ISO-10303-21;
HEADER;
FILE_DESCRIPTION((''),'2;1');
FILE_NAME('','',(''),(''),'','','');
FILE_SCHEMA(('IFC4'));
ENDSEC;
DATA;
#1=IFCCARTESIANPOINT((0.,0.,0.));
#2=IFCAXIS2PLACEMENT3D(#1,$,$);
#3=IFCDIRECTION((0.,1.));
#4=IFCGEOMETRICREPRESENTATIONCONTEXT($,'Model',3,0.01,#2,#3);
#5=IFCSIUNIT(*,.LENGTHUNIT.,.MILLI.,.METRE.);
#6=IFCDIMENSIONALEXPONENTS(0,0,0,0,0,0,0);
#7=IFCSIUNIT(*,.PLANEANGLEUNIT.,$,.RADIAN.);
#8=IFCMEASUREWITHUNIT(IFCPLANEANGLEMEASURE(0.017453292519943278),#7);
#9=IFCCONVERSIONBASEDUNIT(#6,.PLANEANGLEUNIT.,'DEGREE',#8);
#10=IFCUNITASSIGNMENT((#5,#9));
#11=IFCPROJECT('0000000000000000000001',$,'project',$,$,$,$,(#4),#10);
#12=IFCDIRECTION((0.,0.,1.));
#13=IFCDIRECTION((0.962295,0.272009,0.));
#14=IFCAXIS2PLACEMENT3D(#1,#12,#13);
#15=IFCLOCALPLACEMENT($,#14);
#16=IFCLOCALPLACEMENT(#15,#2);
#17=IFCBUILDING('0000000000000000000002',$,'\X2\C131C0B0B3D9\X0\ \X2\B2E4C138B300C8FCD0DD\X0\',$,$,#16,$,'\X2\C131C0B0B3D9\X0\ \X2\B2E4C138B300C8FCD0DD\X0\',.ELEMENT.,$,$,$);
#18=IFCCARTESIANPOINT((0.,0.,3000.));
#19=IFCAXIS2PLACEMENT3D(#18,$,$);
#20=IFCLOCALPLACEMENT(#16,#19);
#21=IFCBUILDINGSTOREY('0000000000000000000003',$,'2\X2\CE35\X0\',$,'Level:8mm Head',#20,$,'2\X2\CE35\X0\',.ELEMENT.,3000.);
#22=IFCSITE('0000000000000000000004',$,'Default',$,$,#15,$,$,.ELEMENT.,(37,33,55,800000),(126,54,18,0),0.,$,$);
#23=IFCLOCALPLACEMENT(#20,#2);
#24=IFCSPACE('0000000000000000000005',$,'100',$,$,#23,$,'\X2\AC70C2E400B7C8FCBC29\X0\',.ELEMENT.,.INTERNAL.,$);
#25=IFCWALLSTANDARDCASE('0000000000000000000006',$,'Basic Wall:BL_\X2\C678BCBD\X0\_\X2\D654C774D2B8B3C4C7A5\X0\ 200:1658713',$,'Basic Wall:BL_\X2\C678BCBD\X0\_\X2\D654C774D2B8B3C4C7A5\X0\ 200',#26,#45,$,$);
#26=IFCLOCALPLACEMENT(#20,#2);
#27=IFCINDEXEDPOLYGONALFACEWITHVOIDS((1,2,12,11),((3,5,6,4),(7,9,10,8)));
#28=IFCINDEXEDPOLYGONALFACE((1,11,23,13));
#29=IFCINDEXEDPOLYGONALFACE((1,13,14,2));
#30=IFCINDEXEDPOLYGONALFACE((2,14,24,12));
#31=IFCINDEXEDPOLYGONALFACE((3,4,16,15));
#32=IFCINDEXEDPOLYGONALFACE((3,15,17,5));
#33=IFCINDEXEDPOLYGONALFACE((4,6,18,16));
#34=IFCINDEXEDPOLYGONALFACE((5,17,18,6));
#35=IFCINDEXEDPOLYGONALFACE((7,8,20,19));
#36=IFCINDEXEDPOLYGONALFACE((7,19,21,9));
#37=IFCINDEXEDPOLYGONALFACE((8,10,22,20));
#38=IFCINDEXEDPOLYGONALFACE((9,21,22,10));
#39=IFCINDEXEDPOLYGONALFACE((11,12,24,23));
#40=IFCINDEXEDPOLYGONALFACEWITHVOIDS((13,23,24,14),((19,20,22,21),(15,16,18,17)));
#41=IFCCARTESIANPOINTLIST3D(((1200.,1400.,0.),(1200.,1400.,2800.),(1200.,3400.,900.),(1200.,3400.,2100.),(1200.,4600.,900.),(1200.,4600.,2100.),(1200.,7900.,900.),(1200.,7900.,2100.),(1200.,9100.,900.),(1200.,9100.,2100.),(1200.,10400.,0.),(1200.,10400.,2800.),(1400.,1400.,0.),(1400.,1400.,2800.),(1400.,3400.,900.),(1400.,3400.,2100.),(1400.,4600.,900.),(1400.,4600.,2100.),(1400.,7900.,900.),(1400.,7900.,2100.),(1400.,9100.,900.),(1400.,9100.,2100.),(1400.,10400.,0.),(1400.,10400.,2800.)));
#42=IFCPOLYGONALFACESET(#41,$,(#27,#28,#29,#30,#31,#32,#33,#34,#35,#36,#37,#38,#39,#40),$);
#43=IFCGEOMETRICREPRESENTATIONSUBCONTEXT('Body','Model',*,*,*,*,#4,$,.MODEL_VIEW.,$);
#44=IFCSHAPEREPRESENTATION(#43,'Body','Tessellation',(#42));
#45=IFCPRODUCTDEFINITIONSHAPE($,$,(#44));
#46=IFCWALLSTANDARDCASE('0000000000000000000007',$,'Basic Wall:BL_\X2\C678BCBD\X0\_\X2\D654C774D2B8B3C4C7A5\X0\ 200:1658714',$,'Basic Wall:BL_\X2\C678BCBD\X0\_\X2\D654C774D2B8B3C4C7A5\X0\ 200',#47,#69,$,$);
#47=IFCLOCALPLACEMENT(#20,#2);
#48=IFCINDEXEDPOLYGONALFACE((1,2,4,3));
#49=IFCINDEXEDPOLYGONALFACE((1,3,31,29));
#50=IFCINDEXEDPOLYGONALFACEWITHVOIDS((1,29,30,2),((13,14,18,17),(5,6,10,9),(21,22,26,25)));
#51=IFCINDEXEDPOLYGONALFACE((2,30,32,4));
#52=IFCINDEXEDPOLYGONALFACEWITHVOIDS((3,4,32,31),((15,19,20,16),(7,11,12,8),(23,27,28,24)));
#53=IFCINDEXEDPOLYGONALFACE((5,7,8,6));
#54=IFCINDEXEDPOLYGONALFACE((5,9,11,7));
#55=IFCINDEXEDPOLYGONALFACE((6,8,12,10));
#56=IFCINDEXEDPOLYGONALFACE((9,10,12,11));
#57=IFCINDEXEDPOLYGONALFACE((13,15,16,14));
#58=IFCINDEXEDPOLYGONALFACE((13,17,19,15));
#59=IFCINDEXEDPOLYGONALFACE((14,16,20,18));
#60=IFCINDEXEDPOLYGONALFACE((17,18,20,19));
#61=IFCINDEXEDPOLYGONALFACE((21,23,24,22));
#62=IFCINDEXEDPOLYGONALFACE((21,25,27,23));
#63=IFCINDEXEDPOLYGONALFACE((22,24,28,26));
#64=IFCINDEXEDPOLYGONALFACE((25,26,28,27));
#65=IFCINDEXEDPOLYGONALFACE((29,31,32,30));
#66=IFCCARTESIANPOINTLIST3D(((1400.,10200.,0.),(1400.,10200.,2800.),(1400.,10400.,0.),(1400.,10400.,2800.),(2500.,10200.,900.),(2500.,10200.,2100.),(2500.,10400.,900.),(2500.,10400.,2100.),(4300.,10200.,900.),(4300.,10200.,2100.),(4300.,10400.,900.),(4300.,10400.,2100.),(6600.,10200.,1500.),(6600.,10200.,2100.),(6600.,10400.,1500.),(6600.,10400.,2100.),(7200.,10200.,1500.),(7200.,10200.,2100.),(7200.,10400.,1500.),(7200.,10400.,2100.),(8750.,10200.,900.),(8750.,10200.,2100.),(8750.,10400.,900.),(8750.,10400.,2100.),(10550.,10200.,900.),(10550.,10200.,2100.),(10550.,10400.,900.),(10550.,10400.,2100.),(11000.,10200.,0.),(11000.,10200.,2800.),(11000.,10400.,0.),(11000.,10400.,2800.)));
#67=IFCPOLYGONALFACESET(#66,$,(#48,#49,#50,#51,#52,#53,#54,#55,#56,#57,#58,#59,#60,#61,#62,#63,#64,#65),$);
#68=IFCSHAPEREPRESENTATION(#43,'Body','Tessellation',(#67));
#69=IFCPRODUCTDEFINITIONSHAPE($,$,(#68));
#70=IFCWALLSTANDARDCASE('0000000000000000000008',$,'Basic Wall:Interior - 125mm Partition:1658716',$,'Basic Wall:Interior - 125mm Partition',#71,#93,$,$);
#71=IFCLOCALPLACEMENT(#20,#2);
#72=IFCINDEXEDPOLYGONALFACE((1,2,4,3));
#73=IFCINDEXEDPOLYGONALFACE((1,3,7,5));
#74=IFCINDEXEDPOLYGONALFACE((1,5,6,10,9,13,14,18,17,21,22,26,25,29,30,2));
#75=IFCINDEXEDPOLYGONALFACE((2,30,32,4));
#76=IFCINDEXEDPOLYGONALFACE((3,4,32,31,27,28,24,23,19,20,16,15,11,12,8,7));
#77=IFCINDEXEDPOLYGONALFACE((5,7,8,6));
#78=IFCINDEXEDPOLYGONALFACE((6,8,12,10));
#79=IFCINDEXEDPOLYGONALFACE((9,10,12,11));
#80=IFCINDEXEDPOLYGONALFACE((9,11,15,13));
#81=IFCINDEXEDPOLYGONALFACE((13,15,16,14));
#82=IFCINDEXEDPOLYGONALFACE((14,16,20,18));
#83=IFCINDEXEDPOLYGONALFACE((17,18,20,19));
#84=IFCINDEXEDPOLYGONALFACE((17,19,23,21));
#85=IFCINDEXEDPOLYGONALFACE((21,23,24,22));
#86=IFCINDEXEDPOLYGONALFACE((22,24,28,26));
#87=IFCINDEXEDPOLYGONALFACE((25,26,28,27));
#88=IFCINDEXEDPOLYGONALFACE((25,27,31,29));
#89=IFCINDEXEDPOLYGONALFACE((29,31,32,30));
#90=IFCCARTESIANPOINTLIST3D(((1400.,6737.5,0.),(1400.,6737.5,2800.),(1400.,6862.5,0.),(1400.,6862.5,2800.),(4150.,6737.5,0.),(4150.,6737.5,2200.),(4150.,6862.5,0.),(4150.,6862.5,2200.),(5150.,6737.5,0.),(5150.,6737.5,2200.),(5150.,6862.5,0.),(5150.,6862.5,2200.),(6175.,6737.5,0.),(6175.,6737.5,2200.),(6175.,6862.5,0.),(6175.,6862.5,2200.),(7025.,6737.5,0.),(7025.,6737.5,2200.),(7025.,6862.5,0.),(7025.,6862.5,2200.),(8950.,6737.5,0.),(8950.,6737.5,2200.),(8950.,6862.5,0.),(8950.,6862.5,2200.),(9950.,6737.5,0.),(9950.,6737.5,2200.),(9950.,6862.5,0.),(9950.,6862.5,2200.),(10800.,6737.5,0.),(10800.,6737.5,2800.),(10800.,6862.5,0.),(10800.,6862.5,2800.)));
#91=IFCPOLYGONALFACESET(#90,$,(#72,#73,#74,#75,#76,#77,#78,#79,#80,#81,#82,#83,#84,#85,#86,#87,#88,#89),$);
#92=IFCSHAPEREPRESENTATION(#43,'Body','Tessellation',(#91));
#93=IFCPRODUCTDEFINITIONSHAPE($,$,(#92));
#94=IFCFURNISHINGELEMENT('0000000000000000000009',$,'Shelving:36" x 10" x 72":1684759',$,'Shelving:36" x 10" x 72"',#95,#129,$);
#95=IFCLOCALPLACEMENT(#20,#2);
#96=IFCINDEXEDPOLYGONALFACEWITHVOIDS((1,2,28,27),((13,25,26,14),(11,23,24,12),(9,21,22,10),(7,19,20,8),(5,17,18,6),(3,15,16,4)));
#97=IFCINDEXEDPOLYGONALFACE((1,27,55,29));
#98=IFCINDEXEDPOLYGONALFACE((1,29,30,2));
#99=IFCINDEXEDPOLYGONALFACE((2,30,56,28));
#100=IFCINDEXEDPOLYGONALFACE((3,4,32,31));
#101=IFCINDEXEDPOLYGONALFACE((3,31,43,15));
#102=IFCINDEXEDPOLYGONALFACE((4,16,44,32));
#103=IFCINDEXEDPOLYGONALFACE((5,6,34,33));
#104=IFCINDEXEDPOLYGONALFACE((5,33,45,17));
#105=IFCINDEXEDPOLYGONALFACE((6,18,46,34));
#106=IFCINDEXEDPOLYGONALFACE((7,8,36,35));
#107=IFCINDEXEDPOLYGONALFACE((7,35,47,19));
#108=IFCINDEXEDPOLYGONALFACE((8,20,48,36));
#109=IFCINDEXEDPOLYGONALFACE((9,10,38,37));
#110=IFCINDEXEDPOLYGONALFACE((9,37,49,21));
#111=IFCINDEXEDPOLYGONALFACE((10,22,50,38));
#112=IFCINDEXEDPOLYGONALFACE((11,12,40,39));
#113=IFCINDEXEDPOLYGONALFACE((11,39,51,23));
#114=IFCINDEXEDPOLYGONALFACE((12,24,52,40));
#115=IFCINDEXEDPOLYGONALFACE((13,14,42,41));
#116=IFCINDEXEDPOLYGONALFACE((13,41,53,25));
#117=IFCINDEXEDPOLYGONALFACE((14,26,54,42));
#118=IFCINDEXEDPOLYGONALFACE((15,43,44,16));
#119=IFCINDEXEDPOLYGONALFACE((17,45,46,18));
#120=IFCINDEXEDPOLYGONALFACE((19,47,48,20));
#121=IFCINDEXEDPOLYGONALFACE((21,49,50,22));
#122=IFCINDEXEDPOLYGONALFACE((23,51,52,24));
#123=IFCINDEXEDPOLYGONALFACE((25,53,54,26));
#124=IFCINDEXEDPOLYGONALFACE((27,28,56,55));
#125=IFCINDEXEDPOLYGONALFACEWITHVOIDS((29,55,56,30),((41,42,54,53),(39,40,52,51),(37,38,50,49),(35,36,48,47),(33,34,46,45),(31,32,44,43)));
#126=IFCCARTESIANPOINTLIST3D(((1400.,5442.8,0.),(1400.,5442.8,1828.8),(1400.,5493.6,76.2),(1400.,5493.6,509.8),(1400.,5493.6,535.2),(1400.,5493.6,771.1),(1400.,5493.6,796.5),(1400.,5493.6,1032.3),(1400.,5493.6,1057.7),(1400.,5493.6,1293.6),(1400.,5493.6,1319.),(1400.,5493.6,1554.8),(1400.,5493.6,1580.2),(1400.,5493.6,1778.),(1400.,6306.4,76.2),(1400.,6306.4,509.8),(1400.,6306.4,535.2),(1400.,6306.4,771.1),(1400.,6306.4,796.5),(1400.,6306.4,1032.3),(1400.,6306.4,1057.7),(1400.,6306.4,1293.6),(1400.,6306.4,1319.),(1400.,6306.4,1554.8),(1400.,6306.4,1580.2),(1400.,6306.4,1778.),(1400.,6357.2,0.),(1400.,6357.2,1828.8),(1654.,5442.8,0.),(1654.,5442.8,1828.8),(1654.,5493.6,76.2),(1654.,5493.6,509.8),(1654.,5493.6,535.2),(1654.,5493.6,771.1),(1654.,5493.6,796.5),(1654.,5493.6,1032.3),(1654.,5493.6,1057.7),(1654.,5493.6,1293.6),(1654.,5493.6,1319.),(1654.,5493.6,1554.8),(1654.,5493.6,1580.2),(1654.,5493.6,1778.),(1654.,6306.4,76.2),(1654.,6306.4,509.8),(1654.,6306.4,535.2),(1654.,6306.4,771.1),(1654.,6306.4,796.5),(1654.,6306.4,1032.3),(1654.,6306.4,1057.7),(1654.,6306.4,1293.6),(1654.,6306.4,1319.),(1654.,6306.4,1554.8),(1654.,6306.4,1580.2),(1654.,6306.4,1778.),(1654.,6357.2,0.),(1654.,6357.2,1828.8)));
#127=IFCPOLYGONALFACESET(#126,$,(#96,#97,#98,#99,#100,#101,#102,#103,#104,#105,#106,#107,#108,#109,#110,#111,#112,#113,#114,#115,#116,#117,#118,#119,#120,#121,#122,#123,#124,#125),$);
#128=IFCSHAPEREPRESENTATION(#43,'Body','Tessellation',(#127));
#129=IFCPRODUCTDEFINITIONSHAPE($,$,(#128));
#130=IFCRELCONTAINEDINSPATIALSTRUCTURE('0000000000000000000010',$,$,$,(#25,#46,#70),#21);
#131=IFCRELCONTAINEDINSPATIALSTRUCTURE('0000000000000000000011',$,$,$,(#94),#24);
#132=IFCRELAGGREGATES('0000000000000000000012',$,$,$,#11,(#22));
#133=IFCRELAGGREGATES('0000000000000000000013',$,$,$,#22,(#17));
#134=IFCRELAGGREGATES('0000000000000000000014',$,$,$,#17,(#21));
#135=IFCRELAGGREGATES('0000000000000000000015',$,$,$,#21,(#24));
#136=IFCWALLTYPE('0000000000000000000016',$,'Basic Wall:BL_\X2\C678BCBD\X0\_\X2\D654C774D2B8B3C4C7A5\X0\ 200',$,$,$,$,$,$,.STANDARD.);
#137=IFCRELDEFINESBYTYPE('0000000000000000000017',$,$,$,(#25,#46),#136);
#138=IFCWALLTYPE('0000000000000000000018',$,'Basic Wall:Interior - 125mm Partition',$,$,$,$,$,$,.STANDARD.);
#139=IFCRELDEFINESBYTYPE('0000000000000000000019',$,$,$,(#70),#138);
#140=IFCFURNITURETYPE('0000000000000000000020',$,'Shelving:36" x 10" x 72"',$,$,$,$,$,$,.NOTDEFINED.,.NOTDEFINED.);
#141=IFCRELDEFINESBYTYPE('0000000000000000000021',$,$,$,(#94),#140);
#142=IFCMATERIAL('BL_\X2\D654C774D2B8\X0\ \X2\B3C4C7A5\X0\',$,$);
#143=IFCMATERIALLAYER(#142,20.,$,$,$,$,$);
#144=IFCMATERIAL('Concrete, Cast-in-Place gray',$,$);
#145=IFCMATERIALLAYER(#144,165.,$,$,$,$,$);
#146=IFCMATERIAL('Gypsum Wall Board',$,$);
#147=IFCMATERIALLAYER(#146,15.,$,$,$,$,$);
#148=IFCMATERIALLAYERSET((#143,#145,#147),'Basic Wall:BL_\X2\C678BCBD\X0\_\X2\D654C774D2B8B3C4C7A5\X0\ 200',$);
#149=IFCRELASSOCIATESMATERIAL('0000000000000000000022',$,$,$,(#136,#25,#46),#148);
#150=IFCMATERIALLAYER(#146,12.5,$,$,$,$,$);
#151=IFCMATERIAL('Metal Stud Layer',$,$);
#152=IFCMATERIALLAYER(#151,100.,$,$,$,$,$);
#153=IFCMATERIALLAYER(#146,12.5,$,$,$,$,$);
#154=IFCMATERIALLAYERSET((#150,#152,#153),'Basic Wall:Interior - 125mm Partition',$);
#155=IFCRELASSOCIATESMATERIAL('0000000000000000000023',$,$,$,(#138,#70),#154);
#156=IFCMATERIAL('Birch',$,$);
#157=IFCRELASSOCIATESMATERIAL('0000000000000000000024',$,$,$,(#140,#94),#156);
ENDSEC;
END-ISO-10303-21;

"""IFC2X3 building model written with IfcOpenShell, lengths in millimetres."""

from ifc_helpers import new_model, entity, si_unit, converted_unit, direction, frame, frame_2d, origin, place, context, subcontext, project, spatial, polyline, rectangle, outline, extrude, source, transform, mapped, material, layer, layer_set, layer_usage, type_object, type_shapes, element, save


model = new_model("IFC2X3")

# Units and contexts
model_context = context("Model", 3, precision=0.01, world=origin(), true_north=direction((0.0, 1.0)))
body_context = subcontext(model_context, "Body", "Model", "MODEL_VIEW")
ifc_project = project(units=[si_unit("LENGTHUNIT", "METRE", prefix="MILLI"), converted_unit("PLANEANGLEUNIT", "DEGREE", entity("IfcPlaneAngleMeasure", 0.017453292519943278), si_unit("PLANEANGLEUNIT", "RADIAN"), dimensions=[0, 0, 0, 0, 0, 0, 0])], contexts=[model_context])

# Site, building, storey
site_placement = place(None, frame((0.0, 0.0, 0.0), z_axis=(0.0, 0.0, 1.0), x_axis=(0.962295, 0.272009, 0.0)))
site = spatial("IfcSite", under=ifc_project, at=site_placement, Name="Default", CompositionType="ELEMENT", RefLatitude=(37, 33, 55, 800000), RefLongitude=(126, 54, 18, 0), RefElevation=0.0)
building_placement = place(site_placement, origin())
building = spatial("IfcBuilding", under=site, at=building_placement, Name="성산동 다세대주택", LongName="성산동 다세대주택", CompositionType="ELEMENT")
storey_placement = place(building_placement, frame((0.0, 0.0, 3000.0)))
storey = spatial("IfcBuildingStorey", under=building, at=storey_placement, Name="2층", ObjectType="Level:8mm Head", LongName="2층", CompositionType="ELEMENT", Elevation=3000.0)

# Walls, openings
ifc_material_1 = material(Name="BL_화이트 도장")
ifc_layer_1 = layer(ifc_material_1, 20.0)
ifc_material_2 = material(Name="Concrete, Cast-in-Place gray")
ifc_layer_2 = layer(ifc_material_2, 165.0)
ifc_material_3 = material(Name="Gypsum Wall Board")
ifc_layer_3 = layer(ifc_material_3, 15.0)
ifc_layer_set_1 = layer_set([ifc_layer_1, ifc_layer_2, ifc_layer_3], Name="Basic Wall:BL_외벽_화이트도장 200")
ifc_layer_usage_1 = layer_usage(ifc_layer_set_1, "AXIS2", "NEGATIVE", 100.0)
wall_type_1 = type_object("IfcWallType", Name="Basic Wall:BL_외벽_화이트도장 200", PredefinedType="STANDARD", material=ifc_layer_set_1)
wall_1_placement = place(storey_placement, frame((1300.0, 1400.0, 0.0), z_axis=(0.0, 0.0, 1.0), x_axis=(0.0, 1.0, 0.0)))
wall_1 = element("IfcWallStandardCase", 1, at=wall_1_placement, inside=storey, type_object=wall_type_1, material=ifc_layer_usage_1, Name="Basic Wall:BL_외벽_화이트도장 200:1658713", ObjectType="Basic Wall:BL_외벽_화이트도장 200", context=body_context, shape_type="SweptSolid", body=[
    extrude(rectangle(XDim=9000.0, YDim=200.0, at=frame_2d((4500.0, 0.0), x_axis=(-1.0, 0.0))), origin(), (0.0, 0.0, 1.0), 2800.0),
])
opening_1_placement = place(wall_1_placement, frame((2000.0, -100.0, 900.0)))
element("IfcOpeningElement", 2, at=opening_1_placement, cuts=wall_1, ObjectType="Opening", context=body_context, shape_type="SweptSolid", body=[
    extrude(rectangle(XDim=1200.0, YDim=1200.0, at=frame_2d((600.0, 600.0), x_axis=(-1.0, 0.0))), frame((0.0, 0.0, 0.0), z_axis=(0.0, 1.0, 0.0), x_axis=(0.0, 0.0, 1.0)), (0.0, 0.0, 1.0), 200.0),
])
opening_2_placement = place(wall_1_placement, frame((6500.0, -100.0, 900.0)))
element("IfcOpeningElement", 3, at=opening_2_placement, cuts=wall_1, ObjectType="Opening", context=body_context, shape_type="SweptSolid", body=[
    extrude(rectangle(XDim=1200.0, YDim=1200.0, at=frame_2d((600.0, 600.0), x_axis=(-1.0, 0.0))), frame((0.0, 0.0, 0.0), z_axis=(0.0, 1.0, 0.0), x_axis=(0.0, 0.0, 1.0)), (0.0, 0.0, 1.0), 200.0),
])
ifc_layer_usage_2 = layer_usage(ifc_layer_set_1, "AXIS2", "NEGATIVE", 100.0)
wall_2_placement = place(storey_placement, frame((1400.0, 10300.0, 0.0)))
wall_2 = element("IfcWallStandardCase", 4, at=wall_2_placement, inside=storey, type_object=wall_type_1, material=ifc_layer_usage_2, Name="Basic Wall:BL_외벽_화이트도장 200:1658714", ObjectType="Basic Wall:BL_외벽_화이트도장 200", context=body_context, shape_type="SweptSolid", body=[
    extrude(rectangle(XDim=9600.0, YDim=200.0, at=frame_2d((4800.0, 0.0), x_axis=(-1.0, 0.0))), origin(), (0.0, 0.0, 1.0), 2800.0),
])
opening_3_placement = place(wall_2_placement, frame((1100.0, -100.0, 900.0)))
element("IfcOpeningElement", 5, at=opening_3_placement, cuts=wall_2, ObjectType="Opening", context=body_context, shape_type="SweptSolid", body=[
    extrude(rectangle(XDim=1200.0, YDim=1800.0, at=frame_2d((600.0, 900.0), x_axis=(-1.0, 0.0))), frame((0.0, 0.0, 0.0), z_axis=(0.0, 1.0, 0.0), x_axis=(0.0, 0.0, 1.0)), (0.0, 0.0, 1.0), 200.0),
])
opening_4_placement = place(wall_2_placement, frame((5200.0, -100.0, 1500.0)))
element("IfcOpeningElement", 6, at=opening_4_placement, cuts=wall_2, ObjectType="Opening", context=body_context, shape_type="SweptSolid", body=[
    extrude(rectangle(XDim=600.0, YDim=600.0, at=frame_2d((300.0, 300.0), x_axis=(-1.0, 0.0))), frame((0.0, 0.0, 0.0), z_axis=(0.0, 1.0, 0.0), x_axis=(0.0, 0.0, 1.0)), (0.0, 0.0, 1.0), 200.0),
])
opening_5_placement = place(wall_2_placement, frame((7350.0, -100.0, 900.0)))
element("IfcOpeningElement", 7, at=opening_5_placement, cuts=wall_2, ObjectType="Opening", context=body_context, shape_type="SweptSolid", body=[
    extrude(rectangle(XDim=1200.0, YDim=1800.0, at=frame_2d((600.0, 900.0), x_axis=(-1.0, 0.0))), frame((0.0, 0.0, 0.0), z_axis=(0.0, 1.0, 0.0), x_axis=(0.0, 0.0, 1.0)), (0.0, 0.0, 1.0), 200.0),
])
ifc_layer_4 = layer(ifc_material_3, 12.5)
ifc_material_4 = material(Name="Metal Stud Layer")
ifc_layer_5 = layer(ifc_material_4, 100.0)
ifc_layer_6 = layer(ifc_material_3, 12.5)
ifc_layer_set_2 = layer_set([ifc_layer_4, ifc_layer_5, ifc_layer_6], Name="Basic Wall:Interior - 125mm Partition")
ifc_layer_usage_3 = layer_usage(ifc_layer_set_2, "AXIS2", "NEGATIVE", 62.5)
wall_type_2 = type_object("IfcWallType", Name="Basic Wall:Interior - 125mm Partition", PredefinedType="STANDARD", material=ifc_layer_set_2)
wall_3_placement = place(storey_placement, frame((1400.0, 6800.0, 0.0)))
wall_3 = element("IfcWallStandardCase", 8, at=wall_3_placement, inside=storey, type_object=wall_type_2, material=ifc_layer_usage_3, Name="Basic Wall:Interior - 125mm Partition:1658716", ObjectType="Basic Wall:Interior - 125mm Partition", context=body_context, shape_type="SweptSolid", body=[
    extrude(rectangle(XDim=9400.0, YDim=125.0, at=frame_2d((4700.0, 0.0), x_axis=(1.0, 0.0))), origin(), (0.0, 0.0, 1.0), 2800.0),
])
opening_6_placement = place(wall_3_placement, frame((7550.0, -62.5, 0.0)))
element("IfcOpeningElement", 9, at=opening_6_placement, cuts=wall_3, ObjectType="Opening", context=body_context, shape_type="SweptSolid", body=[
    extrude(rectangle(XDim=2200.0, YDim=1000.0, at=frame_2d((1100.0, 500.0), x_axis=(1.0, 0.0))), frame((0.0, 0.0, 0.0), z_axis=(0.0, 1.0, 0.0), x_axis=(0.0, 0.0, 1.0)), (0.0, 0.0, 1.0), 125.0),
])
opening_7_placement = place(wall_3_placement, frame((4775.0, -62.5, 0.0)))
element("IfcOpeningElement", 10, at=opening_7_placement, cuts=wall_3, ObjectType="Opening", context=body_context, shape_type="SweptSolid", body=[
    extrude(rectangle(XDim=2200.0, YDim=850.0, at=frame_2d((1100.0, 425.0), x_axis=(1.0, 0.0))), frame((0.0, 0.0, 0.0), z_axis=(0.0, 1.0, 0.0), x_axis=(0.0, 0.0, 1.0)), (0.0, 0.0, 1.0), 125.0),
])
opening_8_placement = place(wall_3_placement, frame((2750.0, -62.5, 0.0)))
element("IfcOpeningElement", 11, at=opening_8_placement, cuts=wall_3, ObjectType="Opening", context=body_context, shape_type="SweptSolid", body=[
    extrude(rectangle(XDim=2200.0, YDim=1000.0, at=frame_2d((1100.0, 500.0), x_axis=(1.0, 0.0))), frame((0.0, 0.0, 0.0), z_axis=(0.0, 1.0, 0.0), x_axis=(0.0, 0.0, 1.0)), (0.0, 0.0, 1.0), 125.0),
])

# Shared definitions
space_1_placement = place(storey_placement, origin())
space_1 = spatial("IfcSpace", under=storey, at=space_1_placement, Name="100", LongName="거실·주방", CompositionType="ELEMENT", InteriorOrExteriorSpace="INTERNAL")

# Furnishing element
ifc_material_5 = material(Name="Birch")
furniture_type_1 = type_object("IfcFurnitureType", Name="Shelving:36\" x 10\" x 72\"", AssemblyPlace="NOTDEFINED", material=ifc_material_5)
shared_shape_1 = source(origin(), body_context, "Body", "SweptSolid", [
    extrude(outline(polyline([(-457.2, -914.4), (457.2, -914.4), (457.2, 914.4), (-457.2, 914.4), (-457.2, -914.4)]), holes=[polyline([(-406.4, 863.6), (406.4, 863.6), (406.4, 665.8), (-406.4, 665.8), (-406.4, 863.6)]), polyline([(-406.4, -838.2), (-406.4, -404.6), (406.4, -404.6), (406.4, -838.2), (-406.4, -838.2)]), polyline([(406.4, 143.3), (-406.4, 143.3), (-406.4, 379.2), (406.4, 379.2), (406.4, 143.3)]), polyline([(-406.4, 640.4), (406.4, 640.4), (406.4, 404.6), (-406.4, 404.6), (-406.4, 640.4)]), polyline([(-406.4, 117.9), (406.4, 117.9), (406.4, -117.9), (-406.4, -117.9), (-406.4, 117.9)]), polyline([(-406.4, -143.3), (406.4, -143.3), (406.4, -379.2), (-406.4, -379.2), (-406.4, -143.3)])]), frame((0.0, -431.8, 914.4), z_axis=(0.0, 1.0, 0.0), x_axis=(-1.0, 0.0, 0.0)), (0.0, 0.0, 1.0), 254.0),
])
type_shapes(furniture_type_1, [shared_shape_1])
furnishing_1_placement = place(space_1_placement, frame((1222.2, 5900.0, 0.0), z_axis=(0.0, 0.0, 1.0), x_axis=(0.0, 1.0, 0.0)))
element("IfcFurnishingElement", 12, at=furnishing_1_placement, inside=space_1, type_object=furniture_type_1, material=ifc_material_5, Name="Shelving:36\" x 10\" x 72\":1684759", ObjectType="Shelving:36\" x 10\" x 72\"", context=body_context, shape_type="MappedRepresentation", body=[
    mapped(shared_shape_1, transform((0.0, 0.0, 0.0), scale=1.0)),
])

save(model, "model.ifc")
